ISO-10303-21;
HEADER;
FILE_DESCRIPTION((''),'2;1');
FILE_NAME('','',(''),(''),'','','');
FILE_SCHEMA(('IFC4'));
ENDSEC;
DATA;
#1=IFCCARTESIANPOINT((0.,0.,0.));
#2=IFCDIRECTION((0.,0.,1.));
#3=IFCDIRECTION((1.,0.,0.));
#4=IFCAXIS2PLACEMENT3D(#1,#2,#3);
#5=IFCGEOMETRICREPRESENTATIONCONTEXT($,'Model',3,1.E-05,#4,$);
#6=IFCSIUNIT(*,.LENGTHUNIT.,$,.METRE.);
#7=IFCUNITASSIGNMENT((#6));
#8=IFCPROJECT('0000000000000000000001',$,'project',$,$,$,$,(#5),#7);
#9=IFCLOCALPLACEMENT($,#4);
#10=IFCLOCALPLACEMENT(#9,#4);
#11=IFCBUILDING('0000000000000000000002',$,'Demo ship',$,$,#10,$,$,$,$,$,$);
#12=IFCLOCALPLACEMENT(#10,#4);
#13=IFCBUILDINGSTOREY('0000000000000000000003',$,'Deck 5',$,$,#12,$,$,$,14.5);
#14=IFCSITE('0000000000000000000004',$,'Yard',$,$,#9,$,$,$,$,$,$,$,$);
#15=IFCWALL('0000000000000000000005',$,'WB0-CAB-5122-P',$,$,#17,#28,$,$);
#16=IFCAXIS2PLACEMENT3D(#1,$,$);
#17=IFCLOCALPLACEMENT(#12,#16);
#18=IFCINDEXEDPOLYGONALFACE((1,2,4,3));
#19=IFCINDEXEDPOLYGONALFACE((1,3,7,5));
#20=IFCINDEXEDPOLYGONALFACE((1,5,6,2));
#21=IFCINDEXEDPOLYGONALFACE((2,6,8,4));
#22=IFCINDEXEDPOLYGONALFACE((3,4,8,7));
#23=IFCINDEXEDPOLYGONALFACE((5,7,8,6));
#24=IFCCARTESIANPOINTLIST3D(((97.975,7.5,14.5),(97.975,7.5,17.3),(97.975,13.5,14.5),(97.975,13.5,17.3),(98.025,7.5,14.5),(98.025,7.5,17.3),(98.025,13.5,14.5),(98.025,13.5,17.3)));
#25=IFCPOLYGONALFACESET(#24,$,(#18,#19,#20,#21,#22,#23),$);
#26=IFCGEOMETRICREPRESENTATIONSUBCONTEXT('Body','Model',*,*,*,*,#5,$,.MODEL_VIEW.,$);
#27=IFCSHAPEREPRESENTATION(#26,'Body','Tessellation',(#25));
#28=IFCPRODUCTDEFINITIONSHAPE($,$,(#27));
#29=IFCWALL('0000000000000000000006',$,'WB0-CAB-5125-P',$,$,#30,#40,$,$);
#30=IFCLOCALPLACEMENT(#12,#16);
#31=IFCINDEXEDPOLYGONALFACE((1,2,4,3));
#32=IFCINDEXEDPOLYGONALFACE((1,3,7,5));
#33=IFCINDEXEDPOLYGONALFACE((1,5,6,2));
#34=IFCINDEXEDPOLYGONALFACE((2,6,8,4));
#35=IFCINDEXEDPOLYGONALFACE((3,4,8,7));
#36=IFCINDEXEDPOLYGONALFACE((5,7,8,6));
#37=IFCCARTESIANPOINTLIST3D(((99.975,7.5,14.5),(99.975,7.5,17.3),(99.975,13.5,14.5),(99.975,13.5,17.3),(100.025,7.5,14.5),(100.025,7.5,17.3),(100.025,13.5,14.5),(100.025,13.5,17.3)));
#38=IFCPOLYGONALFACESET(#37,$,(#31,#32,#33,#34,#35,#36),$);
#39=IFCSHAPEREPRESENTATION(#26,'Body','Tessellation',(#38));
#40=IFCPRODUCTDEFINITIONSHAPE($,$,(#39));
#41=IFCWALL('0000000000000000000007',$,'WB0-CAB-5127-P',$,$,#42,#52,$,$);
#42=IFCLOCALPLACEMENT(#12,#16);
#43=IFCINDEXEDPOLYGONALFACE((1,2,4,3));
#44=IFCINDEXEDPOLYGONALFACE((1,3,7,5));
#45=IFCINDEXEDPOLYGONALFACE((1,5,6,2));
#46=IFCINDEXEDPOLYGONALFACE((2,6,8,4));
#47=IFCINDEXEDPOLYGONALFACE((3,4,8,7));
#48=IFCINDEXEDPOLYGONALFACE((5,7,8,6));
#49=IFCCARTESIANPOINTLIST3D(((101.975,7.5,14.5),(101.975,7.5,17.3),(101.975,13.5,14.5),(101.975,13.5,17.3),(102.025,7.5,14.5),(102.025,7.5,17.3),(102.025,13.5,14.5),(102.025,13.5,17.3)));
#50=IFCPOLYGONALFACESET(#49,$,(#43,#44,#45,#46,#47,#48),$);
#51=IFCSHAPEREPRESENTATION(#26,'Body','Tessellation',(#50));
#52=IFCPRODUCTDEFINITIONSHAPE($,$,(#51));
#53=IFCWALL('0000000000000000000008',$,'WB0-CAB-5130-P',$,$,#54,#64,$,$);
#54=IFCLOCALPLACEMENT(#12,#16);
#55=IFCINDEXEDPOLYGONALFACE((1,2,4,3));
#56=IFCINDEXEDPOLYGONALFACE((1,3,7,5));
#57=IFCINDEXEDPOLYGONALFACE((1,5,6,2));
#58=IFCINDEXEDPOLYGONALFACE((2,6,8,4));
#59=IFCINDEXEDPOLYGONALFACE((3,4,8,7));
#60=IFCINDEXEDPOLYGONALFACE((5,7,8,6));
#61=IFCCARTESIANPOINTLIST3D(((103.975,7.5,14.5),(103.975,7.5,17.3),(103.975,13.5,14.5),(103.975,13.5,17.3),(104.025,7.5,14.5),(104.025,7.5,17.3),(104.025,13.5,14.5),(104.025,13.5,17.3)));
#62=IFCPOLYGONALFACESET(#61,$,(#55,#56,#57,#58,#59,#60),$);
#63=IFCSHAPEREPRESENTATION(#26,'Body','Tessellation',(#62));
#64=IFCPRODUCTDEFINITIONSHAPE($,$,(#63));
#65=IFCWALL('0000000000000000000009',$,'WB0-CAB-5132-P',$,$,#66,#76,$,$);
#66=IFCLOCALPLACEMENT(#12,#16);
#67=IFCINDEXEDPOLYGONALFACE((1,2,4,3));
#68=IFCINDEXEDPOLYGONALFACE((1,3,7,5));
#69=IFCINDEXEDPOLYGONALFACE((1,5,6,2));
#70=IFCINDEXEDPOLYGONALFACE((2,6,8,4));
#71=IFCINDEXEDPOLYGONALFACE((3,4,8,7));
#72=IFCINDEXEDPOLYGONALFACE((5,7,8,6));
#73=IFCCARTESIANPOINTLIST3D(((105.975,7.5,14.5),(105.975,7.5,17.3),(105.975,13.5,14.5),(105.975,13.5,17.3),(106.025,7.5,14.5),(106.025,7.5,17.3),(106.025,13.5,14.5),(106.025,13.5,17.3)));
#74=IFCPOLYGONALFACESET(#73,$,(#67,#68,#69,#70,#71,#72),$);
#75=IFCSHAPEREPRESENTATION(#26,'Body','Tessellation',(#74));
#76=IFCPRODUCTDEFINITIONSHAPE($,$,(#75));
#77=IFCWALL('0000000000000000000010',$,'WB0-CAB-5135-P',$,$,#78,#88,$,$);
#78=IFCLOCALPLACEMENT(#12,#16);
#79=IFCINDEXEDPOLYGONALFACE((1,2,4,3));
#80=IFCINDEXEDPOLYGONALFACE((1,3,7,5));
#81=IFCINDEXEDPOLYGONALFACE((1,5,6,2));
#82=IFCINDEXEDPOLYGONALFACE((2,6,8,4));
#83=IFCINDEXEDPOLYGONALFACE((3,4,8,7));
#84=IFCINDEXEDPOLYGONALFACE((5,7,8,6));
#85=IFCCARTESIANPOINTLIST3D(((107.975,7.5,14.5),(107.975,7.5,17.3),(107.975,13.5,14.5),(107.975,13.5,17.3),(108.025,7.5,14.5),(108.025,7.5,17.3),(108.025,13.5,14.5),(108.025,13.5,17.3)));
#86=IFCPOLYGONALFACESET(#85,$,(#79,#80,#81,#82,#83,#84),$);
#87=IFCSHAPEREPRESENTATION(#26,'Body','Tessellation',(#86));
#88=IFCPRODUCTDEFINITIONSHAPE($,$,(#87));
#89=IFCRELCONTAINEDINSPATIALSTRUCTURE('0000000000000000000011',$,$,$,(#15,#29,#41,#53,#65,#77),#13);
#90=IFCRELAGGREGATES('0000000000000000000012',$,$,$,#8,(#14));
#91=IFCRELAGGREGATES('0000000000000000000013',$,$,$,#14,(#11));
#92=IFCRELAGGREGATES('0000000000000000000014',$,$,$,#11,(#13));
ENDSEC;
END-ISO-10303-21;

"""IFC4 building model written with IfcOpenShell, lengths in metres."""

from ifc_helpers import new_model, si_unit, frame, frame_2d, origin, origin_with_axes, place, context, subcontext, project, spatial, rectangle, extrude, element, save


model = new_model("IFC4")

# Units and contexts
model_context = context("Model", 3, precision=1e-05, world=origin_with_axes())
body_context = subcontext(model_context, "Body", "Model", "MODEL_VIEW")
ifc_project = project(units=[si_unit("LENGTHUNIT", "METRE")], contexts=[model_context])

# Site, building, storey
site_placement = place(None, origin_with_axes())
site = spatial("IfcSite", under=ifc_project, at=site_placement, Name="Yard")
building_placement = place(site_placement, origin_with_axes())
building = spatial("IfcBuilding", under=site, at=building_placement, Name="Demo ship")
storey_placement = place(building_placement, origin_with_axes())
storey = spatial("IfcBuildingStorey", under=building, at=storey_placement, Name="Deck 5", Elevation=14.5)

# Walls
for number, where, z_axis, x_axis, name in (
    (1, (97.975, 7.5, 14.5), (0.0, 0.0, 1.0), (1.0, 0.0, 0.0), "WB0-CAB-5122-P"),
    (2, (99.975, 7.5, 14.5), (0.0, 0.0, 1.0), (1.0, 0.0, 0.0), "WB0-CAB-5125-P"),
    (3, (101.975, 7.5, 14.5), (0.0, 0.0, 1.0), (1.0, 0.0, 0.0), "WB0-CAB-5127-P"),
    (4, (103.975, 7.5, 14.5), (0.0, 0.0, 1.0), (1.0, 0.0, 0.0), "WB0-CAB-5130-P"),
    (5, (105.975, 7.5, 14.5), (0.0, 0.0, 1.0), (1.0, 0.0, 0.0), "WB0-CAB-5132-P"),
    (6, (107.975, 7.5, 14.5), (0.0, 0.0, 1.0), (1.0, 0.0, 0.0), "WB0-CAB-5135-P"),
):
    element("IfcWall", number, at=place(storey_placement, frame(where, z_axis=z_axis, x_axis=x_axis)), inside=storey, Name=name, context=body_context, shape_type="SweptSolid", body=[
        extrude(rectangle(XDim=0.05, YDim=6.0, at=frame_2d((0.025, 3.0))), origin(), (0.0, 0.0, 1.0), 2.8),
    ])

save(model, "model.ifc")
